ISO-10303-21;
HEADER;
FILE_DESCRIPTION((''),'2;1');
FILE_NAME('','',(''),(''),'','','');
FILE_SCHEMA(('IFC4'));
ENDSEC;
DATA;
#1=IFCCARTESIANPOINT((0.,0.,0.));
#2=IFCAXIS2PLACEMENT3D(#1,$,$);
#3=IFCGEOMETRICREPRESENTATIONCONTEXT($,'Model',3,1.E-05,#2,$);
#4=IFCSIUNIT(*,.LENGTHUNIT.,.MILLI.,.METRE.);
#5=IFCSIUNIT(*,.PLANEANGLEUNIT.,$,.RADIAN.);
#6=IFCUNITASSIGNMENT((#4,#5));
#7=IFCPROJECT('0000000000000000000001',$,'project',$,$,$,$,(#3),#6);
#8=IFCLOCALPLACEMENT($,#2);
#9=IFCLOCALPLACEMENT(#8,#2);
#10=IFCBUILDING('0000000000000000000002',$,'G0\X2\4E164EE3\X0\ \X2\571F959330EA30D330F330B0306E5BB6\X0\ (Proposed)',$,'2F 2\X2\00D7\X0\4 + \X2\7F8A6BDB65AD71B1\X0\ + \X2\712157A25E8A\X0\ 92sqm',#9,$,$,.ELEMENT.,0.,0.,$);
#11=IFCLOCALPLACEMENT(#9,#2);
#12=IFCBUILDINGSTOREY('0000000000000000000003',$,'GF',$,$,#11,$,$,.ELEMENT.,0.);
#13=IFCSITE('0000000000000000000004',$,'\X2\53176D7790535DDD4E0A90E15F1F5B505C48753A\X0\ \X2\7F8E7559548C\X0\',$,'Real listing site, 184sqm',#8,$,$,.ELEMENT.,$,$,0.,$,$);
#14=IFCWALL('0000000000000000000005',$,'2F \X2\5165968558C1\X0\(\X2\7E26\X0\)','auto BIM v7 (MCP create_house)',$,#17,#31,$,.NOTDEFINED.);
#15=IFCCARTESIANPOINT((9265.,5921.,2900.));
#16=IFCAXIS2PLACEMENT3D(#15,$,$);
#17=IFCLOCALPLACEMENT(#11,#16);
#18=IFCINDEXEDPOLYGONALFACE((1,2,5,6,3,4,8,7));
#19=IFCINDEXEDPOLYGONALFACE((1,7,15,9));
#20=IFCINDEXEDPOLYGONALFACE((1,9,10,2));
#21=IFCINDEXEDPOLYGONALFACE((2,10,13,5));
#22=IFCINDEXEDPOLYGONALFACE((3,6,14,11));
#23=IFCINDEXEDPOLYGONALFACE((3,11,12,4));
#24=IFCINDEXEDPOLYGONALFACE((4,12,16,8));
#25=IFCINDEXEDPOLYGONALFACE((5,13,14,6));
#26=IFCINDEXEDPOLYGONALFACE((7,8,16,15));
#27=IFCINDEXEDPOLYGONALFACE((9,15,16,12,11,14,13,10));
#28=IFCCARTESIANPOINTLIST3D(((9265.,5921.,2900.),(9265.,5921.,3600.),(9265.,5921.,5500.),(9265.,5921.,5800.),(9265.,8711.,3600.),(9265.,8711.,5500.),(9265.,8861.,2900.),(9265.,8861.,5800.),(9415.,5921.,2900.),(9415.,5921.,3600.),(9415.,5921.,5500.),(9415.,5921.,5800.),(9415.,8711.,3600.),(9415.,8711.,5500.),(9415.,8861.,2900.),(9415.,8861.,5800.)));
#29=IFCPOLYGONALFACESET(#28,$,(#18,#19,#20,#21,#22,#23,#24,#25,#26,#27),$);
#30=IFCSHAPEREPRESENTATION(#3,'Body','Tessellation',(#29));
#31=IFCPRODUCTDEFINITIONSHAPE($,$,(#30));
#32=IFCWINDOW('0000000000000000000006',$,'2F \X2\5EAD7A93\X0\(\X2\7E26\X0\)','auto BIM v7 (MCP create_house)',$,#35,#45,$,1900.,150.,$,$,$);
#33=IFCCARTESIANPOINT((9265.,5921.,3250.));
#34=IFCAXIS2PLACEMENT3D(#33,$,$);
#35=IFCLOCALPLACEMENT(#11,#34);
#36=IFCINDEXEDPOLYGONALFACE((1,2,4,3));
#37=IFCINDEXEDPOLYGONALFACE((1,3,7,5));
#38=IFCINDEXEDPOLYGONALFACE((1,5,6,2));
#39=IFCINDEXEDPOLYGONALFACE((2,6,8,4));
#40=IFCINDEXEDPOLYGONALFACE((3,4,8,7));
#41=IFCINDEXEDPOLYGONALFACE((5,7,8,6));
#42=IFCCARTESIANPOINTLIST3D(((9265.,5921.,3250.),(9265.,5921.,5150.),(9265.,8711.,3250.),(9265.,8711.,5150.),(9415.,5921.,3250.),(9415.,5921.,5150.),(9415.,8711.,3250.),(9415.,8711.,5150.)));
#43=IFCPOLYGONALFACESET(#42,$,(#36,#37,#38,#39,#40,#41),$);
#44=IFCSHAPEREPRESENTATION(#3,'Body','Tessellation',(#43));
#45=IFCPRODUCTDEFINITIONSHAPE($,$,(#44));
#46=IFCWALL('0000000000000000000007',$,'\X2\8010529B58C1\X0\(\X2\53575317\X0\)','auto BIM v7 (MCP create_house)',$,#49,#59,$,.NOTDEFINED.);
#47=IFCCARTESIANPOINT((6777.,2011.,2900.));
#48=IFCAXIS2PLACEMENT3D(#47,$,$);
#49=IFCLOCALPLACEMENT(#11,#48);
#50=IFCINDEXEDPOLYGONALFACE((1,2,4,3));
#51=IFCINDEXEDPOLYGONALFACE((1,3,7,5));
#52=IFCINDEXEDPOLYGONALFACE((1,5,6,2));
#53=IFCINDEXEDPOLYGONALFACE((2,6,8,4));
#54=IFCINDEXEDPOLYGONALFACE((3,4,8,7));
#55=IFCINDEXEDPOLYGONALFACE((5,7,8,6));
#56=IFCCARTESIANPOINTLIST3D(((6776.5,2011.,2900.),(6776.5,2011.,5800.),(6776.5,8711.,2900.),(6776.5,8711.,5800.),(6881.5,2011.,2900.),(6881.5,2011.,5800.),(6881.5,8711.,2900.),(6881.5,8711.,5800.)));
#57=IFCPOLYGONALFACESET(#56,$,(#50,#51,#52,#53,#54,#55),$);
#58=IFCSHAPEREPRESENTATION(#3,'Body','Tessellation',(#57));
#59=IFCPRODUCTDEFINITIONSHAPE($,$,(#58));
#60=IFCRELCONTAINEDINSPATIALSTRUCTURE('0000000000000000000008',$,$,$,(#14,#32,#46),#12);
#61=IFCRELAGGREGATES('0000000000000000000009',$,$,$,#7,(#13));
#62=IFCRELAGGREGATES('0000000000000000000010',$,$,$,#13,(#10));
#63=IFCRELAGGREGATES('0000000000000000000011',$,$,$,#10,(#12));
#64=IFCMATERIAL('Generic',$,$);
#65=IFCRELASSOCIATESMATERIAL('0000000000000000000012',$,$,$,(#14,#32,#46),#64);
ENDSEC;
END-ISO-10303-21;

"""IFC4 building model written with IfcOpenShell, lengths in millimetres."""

from ifc_helpers import new_model, si_unit, frame, frame_2d, origin, place, context, project, spatial, rectangle, extrude, material, element, fill, save


model = new_model("IFC4")

# Units and contexts
model_context = context("Model", 3, precision=1e-05, world=origin())
ifc_project = project(units=[si_unit("LENGTHUNIT", "METRE", prefix="MILLI"), si_unit("PLANEANGLEUNIT", "RADIAN")], contexts=[model_context])

# Site, building, storey
site_placement = place(None, origin())
site = spatial("IfcSite", under=ifc_project, at=site_placement, Name="北海道川上郡弟子屈町 美留和", ObjectType="Real listing site, 184sqm", CompositionType="ELEMENT", RefElevation=0.0)
building_placement = place(site_placement, origin())
building = spatial("IfcBuilding", under=site, at=building_placement, Name="G0世代 土間リビングの家 (Proposed)", ObjectType="2F 2×4 + 羊毛断熱 + 無垢床 92sqm", CompositionType="ELEMENT", ElevationOfRefHeight=0.0, ElevationOfTerrain=0.0)
storey_placement = place(building_placement, origin())
storey = spatial("IfcBuildingStorey", under=building, at=storey_placement, Name="GF", CompositionType="ELEMENT", Elevation=0.0)

# Shared definitions
ifc_material = material(Name="Generic")

# Wall, opening, window
wall_1_placement = place(storey_placement, frame((9265.0, 5921.0, 2900.0)))
wall_1 = element("IfcWall", 1, at=wall_1_placement, inside=storey, material=ifc_material, Name="2F 入隅壁(縦)", Description="auto BIM v7 (MCP create_house)", PredefinedType="NOTDEFINED", context=model_context, shape_type="SweptSolid", body=[
    extrude(rectangle(XDim=150.0, YDim=2940.0, at=frame_2d((75.0, 1470.0))), frame((9265.0, 5921.0, 2900.0)), (0.0, 0.0, 1.0), 2900.0),
])
opening_1_placement = place(storey_placement, frame((9265.0, 5921.0, 3250.0)))
opening_1 = element("IfcOpeningElement", 2, at=opening_1_placement, cuts=wall_1, PredefinedType="NOTDEFINED", context=model_context, shape_type="SweptSolid", body=[
    extrude(rectangle(XDim=150.0, YDim=2790.0, at=frame_2d((75.0, 1395.0))), frame((9265.0, 5921.0, 3250.0)), (0.0, 0.0, 1.0), 1900.0),
])
window_1_placement = place(storey_placement, frame((9265.0, 5921.0, 3250.0)))
window_1 = element("IfcWindow", 3, at=window_1_placement, inside=storey, material=ifc_material, Name="2F 庭窓(縦)", Description="auto BIM v7 (MCP create_house)", OverallHeight=1900.0, OverallWidth=150.0, context=model_context, shape_type="SweptSolid", body=[
    extrude(rectangle(XDim=150.0, YDim=2790.0, at=frame_2d((75.0, 1395.0))), frame((9265.0, 5921.0, 3250.0)), (0.0, 0.0, 1.0), 1900.0),
])
fill(opening_1, window_1)

# Wall
wall_2_placement = place(storey_placement, frame((6777.0, 2011.0, 2900.0)))
element("IfcWall", 4, at=wall_2_placement, inside=storey, material=ifc_material, Name="耐力壁(南北)", Description="auto BIM v7 (MCP create_house)", PredefinedType="NOTDEFINED", context=model_context, shape_type="SweptSolid", body=[
    extrude(rectangle(XDim=105.0, YDim=6700.0, at=frame_2d((52.0, 3350.0))), frame((6777.0, 2011.0, 2900.0)), (0.0, 0.0, 1.0), 2900.0),
])

save(model, "model.ifc")
